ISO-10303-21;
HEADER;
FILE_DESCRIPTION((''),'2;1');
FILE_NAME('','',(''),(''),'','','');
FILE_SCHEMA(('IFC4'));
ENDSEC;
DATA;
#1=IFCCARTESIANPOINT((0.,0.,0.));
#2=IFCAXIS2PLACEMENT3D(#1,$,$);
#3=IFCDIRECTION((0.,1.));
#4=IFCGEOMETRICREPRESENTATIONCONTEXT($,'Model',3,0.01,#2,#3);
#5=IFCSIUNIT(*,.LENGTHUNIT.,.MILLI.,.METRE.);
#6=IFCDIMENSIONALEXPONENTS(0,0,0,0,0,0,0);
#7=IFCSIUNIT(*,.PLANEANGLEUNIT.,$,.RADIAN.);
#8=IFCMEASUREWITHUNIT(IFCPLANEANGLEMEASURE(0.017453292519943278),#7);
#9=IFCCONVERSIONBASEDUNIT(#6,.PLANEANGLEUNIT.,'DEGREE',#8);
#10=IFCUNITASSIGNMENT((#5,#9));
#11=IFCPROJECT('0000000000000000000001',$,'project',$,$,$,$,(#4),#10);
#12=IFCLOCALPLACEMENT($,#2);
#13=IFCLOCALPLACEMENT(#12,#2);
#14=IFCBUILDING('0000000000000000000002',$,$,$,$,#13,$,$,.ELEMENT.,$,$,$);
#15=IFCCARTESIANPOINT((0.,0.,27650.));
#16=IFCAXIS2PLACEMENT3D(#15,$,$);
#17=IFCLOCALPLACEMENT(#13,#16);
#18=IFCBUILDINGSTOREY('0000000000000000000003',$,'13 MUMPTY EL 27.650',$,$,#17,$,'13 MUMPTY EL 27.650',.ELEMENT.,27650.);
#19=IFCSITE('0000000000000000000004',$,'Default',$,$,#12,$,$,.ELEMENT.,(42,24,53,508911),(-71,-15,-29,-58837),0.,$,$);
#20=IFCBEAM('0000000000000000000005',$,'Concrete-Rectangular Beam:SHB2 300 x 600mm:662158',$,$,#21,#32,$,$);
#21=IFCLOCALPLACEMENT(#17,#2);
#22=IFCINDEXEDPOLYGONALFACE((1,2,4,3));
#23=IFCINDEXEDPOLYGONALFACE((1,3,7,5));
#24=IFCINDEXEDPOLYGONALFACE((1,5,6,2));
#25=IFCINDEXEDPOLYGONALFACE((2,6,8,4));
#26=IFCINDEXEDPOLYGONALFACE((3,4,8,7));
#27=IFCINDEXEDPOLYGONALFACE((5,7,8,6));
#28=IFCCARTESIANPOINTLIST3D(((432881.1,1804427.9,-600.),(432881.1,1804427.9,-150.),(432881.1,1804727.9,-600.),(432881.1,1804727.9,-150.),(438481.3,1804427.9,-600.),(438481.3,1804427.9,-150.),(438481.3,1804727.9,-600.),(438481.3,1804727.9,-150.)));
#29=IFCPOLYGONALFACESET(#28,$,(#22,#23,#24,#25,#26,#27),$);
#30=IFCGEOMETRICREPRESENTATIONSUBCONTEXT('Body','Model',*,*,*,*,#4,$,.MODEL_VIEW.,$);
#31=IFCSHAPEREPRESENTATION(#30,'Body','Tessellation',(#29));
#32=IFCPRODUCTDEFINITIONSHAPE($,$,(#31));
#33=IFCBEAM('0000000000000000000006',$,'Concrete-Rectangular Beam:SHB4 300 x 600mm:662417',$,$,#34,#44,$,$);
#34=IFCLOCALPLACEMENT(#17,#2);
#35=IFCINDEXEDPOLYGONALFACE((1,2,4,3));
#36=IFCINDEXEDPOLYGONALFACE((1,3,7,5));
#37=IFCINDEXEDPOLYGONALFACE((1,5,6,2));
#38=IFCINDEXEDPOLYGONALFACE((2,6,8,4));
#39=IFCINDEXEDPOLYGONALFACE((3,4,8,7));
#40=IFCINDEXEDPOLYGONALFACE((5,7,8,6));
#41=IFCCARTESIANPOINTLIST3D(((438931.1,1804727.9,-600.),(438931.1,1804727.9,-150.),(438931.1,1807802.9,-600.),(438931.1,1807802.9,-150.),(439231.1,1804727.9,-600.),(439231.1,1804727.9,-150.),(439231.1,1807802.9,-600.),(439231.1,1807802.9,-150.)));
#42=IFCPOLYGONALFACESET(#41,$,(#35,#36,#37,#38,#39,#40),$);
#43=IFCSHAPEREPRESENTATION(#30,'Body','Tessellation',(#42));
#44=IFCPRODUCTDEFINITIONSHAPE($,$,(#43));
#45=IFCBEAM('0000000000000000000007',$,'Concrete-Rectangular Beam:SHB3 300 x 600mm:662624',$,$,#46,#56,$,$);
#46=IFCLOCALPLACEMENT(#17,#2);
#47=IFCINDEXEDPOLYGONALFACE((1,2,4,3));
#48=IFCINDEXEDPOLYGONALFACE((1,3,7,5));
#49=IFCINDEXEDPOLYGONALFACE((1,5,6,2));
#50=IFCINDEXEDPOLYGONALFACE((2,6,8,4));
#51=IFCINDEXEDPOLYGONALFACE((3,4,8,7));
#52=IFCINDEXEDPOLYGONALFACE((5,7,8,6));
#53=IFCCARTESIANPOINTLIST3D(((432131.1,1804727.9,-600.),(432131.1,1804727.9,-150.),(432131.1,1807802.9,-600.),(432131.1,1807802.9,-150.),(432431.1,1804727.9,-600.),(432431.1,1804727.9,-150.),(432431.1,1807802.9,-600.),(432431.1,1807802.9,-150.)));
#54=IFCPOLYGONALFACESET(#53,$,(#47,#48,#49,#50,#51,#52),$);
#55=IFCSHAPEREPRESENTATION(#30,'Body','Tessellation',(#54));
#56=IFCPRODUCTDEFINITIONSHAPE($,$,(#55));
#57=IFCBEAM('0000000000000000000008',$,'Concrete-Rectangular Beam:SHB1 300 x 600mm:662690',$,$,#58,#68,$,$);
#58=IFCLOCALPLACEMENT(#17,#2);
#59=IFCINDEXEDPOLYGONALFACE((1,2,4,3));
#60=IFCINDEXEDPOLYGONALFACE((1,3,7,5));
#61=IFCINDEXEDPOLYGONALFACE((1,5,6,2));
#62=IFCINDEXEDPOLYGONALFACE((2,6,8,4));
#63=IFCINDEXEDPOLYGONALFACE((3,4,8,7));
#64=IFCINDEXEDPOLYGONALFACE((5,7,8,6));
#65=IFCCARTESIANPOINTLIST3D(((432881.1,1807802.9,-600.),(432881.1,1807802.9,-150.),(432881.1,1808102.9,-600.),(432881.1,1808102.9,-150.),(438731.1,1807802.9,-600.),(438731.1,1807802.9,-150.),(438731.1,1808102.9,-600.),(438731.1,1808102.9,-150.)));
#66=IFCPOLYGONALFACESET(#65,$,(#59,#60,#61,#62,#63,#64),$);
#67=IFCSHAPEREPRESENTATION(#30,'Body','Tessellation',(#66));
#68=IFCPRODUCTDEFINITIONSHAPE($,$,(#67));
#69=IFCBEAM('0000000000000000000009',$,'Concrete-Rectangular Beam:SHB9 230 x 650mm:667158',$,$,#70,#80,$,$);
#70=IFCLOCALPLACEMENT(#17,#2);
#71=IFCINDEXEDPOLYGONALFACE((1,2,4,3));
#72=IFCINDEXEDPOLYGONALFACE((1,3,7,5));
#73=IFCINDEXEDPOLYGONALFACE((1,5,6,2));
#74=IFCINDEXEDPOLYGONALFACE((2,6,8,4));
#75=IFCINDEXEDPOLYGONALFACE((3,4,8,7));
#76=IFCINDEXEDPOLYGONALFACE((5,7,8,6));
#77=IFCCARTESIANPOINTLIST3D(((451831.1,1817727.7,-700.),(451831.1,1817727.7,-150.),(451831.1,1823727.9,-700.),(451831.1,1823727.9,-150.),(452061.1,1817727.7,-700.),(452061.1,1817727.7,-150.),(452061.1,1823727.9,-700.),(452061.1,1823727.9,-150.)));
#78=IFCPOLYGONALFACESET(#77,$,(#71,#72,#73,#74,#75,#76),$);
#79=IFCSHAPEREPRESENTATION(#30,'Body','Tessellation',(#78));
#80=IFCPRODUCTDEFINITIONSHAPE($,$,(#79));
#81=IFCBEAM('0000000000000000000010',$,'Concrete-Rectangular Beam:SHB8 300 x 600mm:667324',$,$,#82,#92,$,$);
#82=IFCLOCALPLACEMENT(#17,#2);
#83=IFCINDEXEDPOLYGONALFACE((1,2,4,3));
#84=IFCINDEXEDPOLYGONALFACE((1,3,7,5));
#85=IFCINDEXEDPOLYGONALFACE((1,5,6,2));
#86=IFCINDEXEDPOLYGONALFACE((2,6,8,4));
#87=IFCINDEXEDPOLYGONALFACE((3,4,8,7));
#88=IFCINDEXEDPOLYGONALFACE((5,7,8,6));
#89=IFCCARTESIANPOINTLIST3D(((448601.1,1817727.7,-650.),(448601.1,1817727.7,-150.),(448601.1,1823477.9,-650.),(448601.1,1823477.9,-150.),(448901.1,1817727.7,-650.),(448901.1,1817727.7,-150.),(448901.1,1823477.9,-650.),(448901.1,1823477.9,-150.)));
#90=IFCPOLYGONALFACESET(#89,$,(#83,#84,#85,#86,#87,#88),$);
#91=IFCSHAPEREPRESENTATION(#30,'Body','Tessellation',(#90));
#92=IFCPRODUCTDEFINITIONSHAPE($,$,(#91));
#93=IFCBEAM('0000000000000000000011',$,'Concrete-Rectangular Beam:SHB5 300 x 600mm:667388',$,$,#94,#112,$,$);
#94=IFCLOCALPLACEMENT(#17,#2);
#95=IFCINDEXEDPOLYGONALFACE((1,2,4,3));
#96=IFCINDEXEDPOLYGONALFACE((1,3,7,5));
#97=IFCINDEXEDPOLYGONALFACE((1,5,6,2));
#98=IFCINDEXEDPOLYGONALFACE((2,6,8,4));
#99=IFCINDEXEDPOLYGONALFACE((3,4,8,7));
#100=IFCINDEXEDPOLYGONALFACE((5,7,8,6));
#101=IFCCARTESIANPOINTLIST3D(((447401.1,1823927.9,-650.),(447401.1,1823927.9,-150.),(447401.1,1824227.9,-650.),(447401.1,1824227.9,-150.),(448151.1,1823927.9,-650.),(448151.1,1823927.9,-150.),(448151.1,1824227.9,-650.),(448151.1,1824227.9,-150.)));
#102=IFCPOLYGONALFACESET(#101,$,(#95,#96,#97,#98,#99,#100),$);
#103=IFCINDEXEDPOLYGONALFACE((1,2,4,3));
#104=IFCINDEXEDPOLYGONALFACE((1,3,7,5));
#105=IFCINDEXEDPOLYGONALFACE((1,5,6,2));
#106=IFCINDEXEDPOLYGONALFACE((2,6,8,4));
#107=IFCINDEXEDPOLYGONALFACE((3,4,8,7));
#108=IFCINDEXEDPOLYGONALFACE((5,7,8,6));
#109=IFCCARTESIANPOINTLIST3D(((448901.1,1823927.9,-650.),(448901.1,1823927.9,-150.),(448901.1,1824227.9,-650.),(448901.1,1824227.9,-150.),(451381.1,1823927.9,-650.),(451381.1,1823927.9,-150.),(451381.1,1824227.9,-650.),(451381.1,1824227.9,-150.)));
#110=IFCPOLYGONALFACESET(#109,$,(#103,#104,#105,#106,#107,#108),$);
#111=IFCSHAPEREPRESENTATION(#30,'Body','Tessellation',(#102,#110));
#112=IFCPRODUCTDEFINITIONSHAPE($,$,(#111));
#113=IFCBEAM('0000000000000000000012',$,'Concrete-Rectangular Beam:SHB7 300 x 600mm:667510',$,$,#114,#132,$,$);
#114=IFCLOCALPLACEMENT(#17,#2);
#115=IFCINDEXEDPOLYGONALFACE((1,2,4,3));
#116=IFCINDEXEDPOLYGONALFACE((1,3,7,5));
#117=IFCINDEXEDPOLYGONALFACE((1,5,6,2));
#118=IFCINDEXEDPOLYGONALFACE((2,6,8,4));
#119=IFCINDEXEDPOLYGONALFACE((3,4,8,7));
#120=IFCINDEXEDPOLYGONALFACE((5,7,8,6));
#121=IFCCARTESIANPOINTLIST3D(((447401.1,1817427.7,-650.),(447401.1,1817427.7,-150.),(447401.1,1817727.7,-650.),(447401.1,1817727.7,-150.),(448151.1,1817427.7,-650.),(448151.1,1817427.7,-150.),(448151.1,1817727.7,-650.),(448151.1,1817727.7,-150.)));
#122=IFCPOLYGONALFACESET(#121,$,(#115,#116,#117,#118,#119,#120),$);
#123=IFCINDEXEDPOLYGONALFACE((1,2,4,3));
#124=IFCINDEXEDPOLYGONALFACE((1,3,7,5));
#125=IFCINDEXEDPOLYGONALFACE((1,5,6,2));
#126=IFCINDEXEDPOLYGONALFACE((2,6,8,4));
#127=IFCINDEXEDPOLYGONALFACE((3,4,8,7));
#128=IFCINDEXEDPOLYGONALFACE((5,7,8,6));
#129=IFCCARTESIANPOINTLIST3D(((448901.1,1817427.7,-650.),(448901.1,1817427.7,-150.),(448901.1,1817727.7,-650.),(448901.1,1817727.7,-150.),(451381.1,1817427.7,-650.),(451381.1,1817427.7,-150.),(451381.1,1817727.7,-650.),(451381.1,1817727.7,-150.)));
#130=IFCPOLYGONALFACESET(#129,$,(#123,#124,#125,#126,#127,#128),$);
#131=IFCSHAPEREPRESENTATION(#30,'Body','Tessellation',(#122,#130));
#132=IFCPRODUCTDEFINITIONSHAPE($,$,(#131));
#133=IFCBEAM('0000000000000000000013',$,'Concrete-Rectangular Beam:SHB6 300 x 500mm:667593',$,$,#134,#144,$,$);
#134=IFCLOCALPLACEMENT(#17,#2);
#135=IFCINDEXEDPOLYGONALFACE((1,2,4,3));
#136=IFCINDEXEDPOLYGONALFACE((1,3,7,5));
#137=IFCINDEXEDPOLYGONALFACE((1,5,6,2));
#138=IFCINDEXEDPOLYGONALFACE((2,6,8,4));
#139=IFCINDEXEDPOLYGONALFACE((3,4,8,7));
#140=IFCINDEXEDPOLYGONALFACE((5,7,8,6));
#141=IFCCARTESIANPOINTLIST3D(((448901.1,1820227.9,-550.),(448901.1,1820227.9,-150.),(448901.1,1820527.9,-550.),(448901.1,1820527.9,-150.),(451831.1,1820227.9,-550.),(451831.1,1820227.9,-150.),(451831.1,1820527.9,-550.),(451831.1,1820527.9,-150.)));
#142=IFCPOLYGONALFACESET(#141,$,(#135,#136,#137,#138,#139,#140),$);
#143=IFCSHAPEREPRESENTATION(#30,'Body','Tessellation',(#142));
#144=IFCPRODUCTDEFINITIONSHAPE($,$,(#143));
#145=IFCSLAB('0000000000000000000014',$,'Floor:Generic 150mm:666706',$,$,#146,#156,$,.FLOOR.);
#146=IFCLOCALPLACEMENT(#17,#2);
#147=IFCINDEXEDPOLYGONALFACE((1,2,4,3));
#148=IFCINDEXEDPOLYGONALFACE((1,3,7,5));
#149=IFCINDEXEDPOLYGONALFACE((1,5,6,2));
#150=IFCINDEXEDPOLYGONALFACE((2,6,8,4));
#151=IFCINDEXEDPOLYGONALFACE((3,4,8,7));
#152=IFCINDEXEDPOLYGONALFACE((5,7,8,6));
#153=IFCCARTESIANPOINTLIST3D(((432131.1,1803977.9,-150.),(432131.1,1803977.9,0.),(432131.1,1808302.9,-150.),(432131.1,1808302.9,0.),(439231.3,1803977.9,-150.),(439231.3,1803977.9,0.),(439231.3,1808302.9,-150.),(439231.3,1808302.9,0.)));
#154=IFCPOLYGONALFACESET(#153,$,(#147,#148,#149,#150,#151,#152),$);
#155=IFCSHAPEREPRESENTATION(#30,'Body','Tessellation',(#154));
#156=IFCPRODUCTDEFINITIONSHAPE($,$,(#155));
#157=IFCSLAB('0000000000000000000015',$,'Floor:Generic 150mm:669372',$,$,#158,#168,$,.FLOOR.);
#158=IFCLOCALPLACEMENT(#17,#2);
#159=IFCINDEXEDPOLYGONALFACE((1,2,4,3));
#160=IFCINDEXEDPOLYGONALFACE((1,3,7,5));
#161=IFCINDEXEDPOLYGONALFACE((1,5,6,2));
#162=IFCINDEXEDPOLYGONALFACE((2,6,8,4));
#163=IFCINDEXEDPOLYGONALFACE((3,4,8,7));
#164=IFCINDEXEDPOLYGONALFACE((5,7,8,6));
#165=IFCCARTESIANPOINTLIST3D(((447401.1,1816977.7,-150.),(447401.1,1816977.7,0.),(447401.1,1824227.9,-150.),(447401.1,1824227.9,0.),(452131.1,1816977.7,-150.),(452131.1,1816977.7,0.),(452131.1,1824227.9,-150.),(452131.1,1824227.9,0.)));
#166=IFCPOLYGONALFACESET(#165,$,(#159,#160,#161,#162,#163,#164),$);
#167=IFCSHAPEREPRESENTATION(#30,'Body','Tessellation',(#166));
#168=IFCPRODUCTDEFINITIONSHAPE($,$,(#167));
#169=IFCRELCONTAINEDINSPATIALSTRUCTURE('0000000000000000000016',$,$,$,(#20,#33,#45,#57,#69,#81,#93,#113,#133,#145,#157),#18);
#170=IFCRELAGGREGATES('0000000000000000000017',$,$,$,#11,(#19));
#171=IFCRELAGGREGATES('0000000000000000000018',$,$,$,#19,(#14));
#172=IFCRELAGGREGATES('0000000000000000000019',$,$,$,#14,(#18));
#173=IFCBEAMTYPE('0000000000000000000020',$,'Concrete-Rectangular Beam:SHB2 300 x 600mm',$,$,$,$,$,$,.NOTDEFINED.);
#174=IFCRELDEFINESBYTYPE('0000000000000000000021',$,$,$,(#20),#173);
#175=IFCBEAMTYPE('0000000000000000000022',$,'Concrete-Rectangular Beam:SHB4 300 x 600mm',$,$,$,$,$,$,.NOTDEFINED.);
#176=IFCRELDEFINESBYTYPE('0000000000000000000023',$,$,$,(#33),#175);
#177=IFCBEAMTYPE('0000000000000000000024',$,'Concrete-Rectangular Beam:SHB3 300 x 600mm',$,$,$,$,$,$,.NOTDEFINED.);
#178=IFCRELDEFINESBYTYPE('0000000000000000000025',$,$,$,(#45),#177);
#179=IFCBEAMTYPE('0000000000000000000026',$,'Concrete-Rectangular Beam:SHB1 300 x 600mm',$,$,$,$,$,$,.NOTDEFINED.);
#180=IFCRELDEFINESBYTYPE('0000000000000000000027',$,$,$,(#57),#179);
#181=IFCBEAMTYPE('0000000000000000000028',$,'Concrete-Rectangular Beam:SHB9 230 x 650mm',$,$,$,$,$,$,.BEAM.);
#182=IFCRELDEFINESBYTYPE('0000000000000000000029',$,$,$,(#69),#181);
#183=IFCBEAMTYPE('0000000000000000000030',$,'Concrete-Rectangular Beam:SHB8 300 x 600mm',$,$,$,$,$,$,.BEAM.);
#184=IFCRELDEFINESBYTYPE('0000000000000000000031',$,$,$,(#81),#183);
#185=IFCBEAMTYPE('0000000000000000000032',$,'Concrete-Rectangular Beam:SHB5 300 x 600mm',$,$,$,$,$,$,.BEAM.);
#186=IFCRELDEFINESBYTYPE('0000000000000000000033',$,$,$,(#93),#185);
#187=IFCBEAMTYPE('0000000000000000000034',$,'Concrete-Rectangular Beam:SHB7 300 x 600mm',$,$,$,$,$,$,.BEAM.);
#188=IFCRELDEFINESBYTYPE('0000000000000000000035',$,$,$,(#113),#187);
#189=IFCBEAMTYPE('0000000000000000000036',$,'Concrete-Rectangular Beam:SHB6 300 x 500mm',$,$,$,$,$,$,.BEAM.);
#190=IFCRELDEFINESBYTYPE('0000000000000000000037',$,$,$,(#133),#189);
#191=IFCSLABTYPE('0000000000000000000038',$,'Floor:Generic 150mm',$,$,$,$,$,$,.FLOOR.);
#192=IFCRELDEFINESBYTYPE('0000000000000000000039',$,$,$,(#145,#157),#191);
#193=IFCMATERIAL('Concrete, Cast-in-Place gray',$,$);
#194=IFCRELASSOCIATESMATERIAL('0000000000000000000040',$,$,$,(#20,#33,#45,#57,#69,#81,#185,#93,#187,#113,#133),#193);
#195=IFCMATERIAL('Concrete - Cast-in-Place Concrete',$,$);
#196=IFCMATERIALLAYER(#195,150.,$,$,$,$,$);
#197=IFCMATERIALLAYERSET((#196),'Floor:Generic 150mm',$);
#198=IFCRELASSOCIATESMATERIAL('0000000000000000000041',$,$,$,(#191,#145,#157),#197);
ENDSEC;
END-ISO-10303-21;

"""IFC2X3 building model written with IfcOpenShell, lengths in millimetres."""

from ifc_helpers import new_model, entity, si_unit, converted_unit, direction, frame, frame_2d, origin, origin_2d_with_axis, place, context, subcontext, project, spatial, rectangle, extrude, source, transform, mapped, material, layer, layer_set, layer_usage, type_object, type_shapes, element, save


model = new_model("IFC2X3")

# Units and contexts
model_context = context("Model", 3, precision=0.01, world=origin(), true_north=direction((0.0, 1.0)))
body_context = subcontext(model_context, "Body", "Model", "MODEL_VIEW")
ifc_project = project(units=[si_unit("LENGTHUNIT", "METRE", prefix="MILLI"), converted_unit("PLANEANGLEUNIT", "DEGREE", entity("IfcPlaneAngleMeasure", 0.017453292519943278), si_unit("PLANEANGLEUNIT", "RADIAN"), dimensions=[0, 0, 0, 0, 0, 0, 0])], contexts=[model_context])

# Site, building, storey
site_placement = place(None, origin())
site = spatial("IfcSite", under=ifc_project, at=site_placement, Name="Default", CompositionType="ELEMENT", RefLatitude=(42, 24, 53, 508911), RefLongitude=(-71, -15, -29, -58837), RefElevation=0.0)
building_placement = place(site_placement, origin())
building = spatial("IfcBuilding", under=site, at=building_placement, CompositionType="ELEMENT")
storey_placement = place(building_placement, frame((0.0, 0.0, 27650.0)))
storey = spatial("IfcBuildingStorey", under=building, at=storey_placement, Name="13 MUMPTY EL 27.650", LongName="13 MUMPTY EL 27.650", CompositionType="ELEMENT", Elevation=27650.0)

# Beams
ifc_material_1 = material(Name="Concrete, Cast-in-Place gray")
beam_type_1 = type_object("IfcBeamType", Name="Concrete-Rectangular Beam:SHB2 300 x 600mm", PredefinedType="NOTDEFINED")
beam_1_placement = place(storey_placement, frame((432881.1, 1804427.9, 0.0)))
element("IfcBeam", 1, at=beam_1_placement, inside=storey, type_object=beam_type_1, material=ifc_material_1, Name="Concrete-Rectangular Beam:SHB2 300 x 600mm:662158", context=body_context, shape_type="SweptSolid", body=[
    extrude(rectangle(XDim=450.0, YDim=300.0, at=origin_2d_with_axis()), frame((0.0, 150.0, -375.0), z_axis=(1.0, 0.0, 0.0), x_axis=(0.0, 0.0, -1.0)), (0.0, 0.0, 1.0), 5600.2),
])
beam_type_2 = type_object("IfcBeamType", Name="Concrete-Rectangular Beam:SHB4 300 x 600mm", PredefinedType="NOTDEFINED")
beam_2_placement = place(storey_placement, frame((438931.1, 1807842.4, 0.0), z_axis=(0.0, 0.0, 1.0), x_axis=(0.0, -1.0, 0.0)))
element("IfcBeam", 2, at=beam_2_placement, inside=storey, type_object=beam_type_2, material=ifc_material_1, Name="Concrete-Rectangular Beam:SHB4 300 x 600mm:662417", context=body_context, shape_type="SweptSolid", body=[
    extrude(rectangle(XDim=450.0, YDim=300.0, at=origin_2d_with_axis()), frame((39.5, 150.0, -375.0), z_axis=(1.0, 0.0, 0.0), x_axis=(0.0, 0.0, -1.0)), (0.0, 0.0, 1.0), 3075.0),
])
beam_type_3 = type_object("IfcBeamType", Name="Concrete-Rectangular Beam:SHB3 300 x 600mm", PredefinedType="NOTDEFINED")
beam_3_placement = place(storey_placement, frame((432131.1, 1807802.9, 0.0), z_axis=(0.0, 0.0, 1.0), x_axis=(0.0, -1.0, 0.0)))
element("IfcBeam", 3, at=beam_3_placement, inside=storey, type_object=beam_type_3, material=ifc_material_1, Name="Concrete-Rectangular Beam:SHB3 300 x 600mm:662624", context=body_context, shape_type="SweptSolid", body=[
    extrude(rectangle(XDim=450.0, YDim=300.0, at=origin_2d_with_axis()), frame((0.0, 150.0, -375.0), z_axis=(1.0, 0.0, 0.0), x_axis=(0.0, 0.0, -1.0)), (0.0, 0.0, 1.0), 3075.0),
])
beam_type_4 = type_object("IfcBeamType", Name="Concrete-Rectangular Beam:SHB1 300 x 600mm", PredefinedType="NOTDEFINED")
beam_4_placement = place(storey_placement, frame((432881.1, 1807802.9, 0.0)))
element("IfcBeam", 4, at=beam_4_placement, inside=storey, type_object=beam_type_4, material=ifc_material_1, Name="Concrete-Rectangular Beam:SHB1 300 x 600mm:662690", context=body_context, shape_type="SweptSolid", body=[
    extrude(rectangle(XDim=450.0, YDim=300.0, at=origin_2d_with_axis()), frame((0.0, 150.0, -375.0), z_axis=(1.0, 0.0, 0.0), x_axis=(0.0, 0.0, -1.0)), (0.0, 0.0, 1.0), 5850.0),
])
beam_type_5 = type_object("IfcBeamType", Name="Concrete-Rectangular Beam:SHB9 230 x 650mm", PredefinedType="BEAM")
beam_5_placement = place(storey_placement, frame((451831.1, 1823727.9, -50.0), z_axis=(0.0, 0.0, 1.0), x_axis=(0.0, -1.0, 0.0)))
element("IfcBeam", 5, at=beam_5_placement, inside=storey, type_object=beam_type_5, material=ifc_material_1, Name="Concrete-Rectangular Beam:SHB9 230 x 650mm:667158", context=body_context, shape_type="SweptSolid", body=[
    extrude(rectangle(XDim=550.0, YDim=230.0, at=frame_2d((0.0, 0.0), x_axis=(1.0, 0.0))), frame((0.0, 115.0, -375.0), z_axis=(1.0, 0.0, 0.0), x_axis=(0.0, 0.0, -1.0)), (0.0, 0.0, 1.0), 6000.2),
])
beam_type_6 = type_object("IfcBeamType", Name="Concrete-Rectangular Beam:SHB8 300 x 600mm", PredefinedType="BEAM")
beam_6_placement = place(storey_placement, frame((448901.1, 1817727.7, -50.0), z_axis=(0.0, 0.0, 1.0), x_axis=(0.0, 1.0, 0.0)))
element("IfcBeam", 6, at=beam_6_placement, inside=storey, type_object=beam_type_6, material=ifc_material_1, Name="Concrete-Rectangular Beam:SHB8 300 x 600mm:667324", context=body_context, shape_type="SweptSolid", body=[
    extrude(rectangle(XDim=500.0, YDim=300.0, at=frame_2d((0.0, 0.0), x_axis=(1.0, 0.0))), frame((0.0, 150.0, -350.0), z_axis=(1.0, 0.0, 0.0), x_axis=(0.0, 0.0, -1.0)), (0.0, 0.0, 1.0), 5750.2),
])
beam_type_7 = type_object("IfcBeamType", Name="Concrete-Rectangular Beam:SHB5 300 x 600mm", PredefinedType="BEAM", material=ifc_material_1)
shared_shape_1 = source(origin(), body_context, "Body", "SweptSolid", [
    extrude(rectangle(XDim=500.0, YDim=300.0, at=frame_2d((0.0, 0.0), x_axis=(1.0, 0.0))), frame((447401.1, 1824077.9, 27250.0), z_axis=(1.0, 0.0, 0.0), x_axis=(0.0, 0.0, -1.0)), (0.0, 0.0, 1.0), 750.0),
    extrude(rectangle(XDim=500.0, YDim=300.0, at=frame_2d((0.0, 0.0), x_axis=(1.0, 0.0))), frame((448901.1, 1824077.9, 27250.0), z_axis=(1.0, 0.0, 0.0), x_axis=(0.0, 0.0, -1.0)), (0.0, 0.0, 1.0), 2480.0),
])
type_shapes(beam_type_7, [shared_shape_1])
beam_7_placement = place(storey_placement, frame((0.0, 0.0, -27650.0)))
element("IfcBeam", 7, at=beam_7_placement, inside=storey, type_object=beam_type_7, material=ifc_material_1, Name="Concrete-Rectangular Beam:SHB5 300 x 600mm:667388", context=body_context, shape_type="MappedRepresentation", body=[
    mapped(shared_shape_1, transform((0.0, 0.0, 0.0), scale=1.0)),
])
beam_type_8 = type_object("IfcBeamType", Name="Concrete-Rectangular Beam:SHB7 300 x 600mm", PredefinedType="BEAM", material=ifc_material_1)
shared_shape_2 = source(origin(), body_context, "Body", "SweptSolid", [
    extrude(rectangle(XDim=500.0, YDim=300.0, at=frame_2d((0.0, 0.0), x_axis=(1.0, 0.0))), frame((447401.1, 1817577.7, 27250.0), z_axis=(1.0, 0.0, 0.0), x_axis=(0.0, 0.0, -1.0)), (0.0, 0.0, 1.0), 750.0),
    extrude(rectangle(XDim=500.0, YDim=300.0, at=frame_2d((0.0, 0.0), x_axis=(1.0, 0.0))), frame((448901.1, 1817577.7, 27250.0), z_axis=(1.0, 0.0, 0.0), x_axis=(0.0, 0.0, -1.0)), (0.0, 0.0, 1.0), 2480.0),
])
type_shapes(beam_type_8, [shared_shape_2])
beam_8_placement = place(storey_placement, frame((0.0, 0.0, -27650.0)))
element("IfcBeam", 8, at=beam_8_placement, inside=storey, type_object=beam_type_8, material=ifc_material_1, Name="Concrete-Rectangular Beam:SHB7 300 x 600mm:667510", context=body_context, shape_type="MappedRepresentation", body=[
    mapped(shared_shape_2, transform((0.0, 0.0, 0.0), scale=1.0)),
])
beam_type_9 = type_object("IfcBeamType", Name="Concrete-Rectangular Beam:SHB6 300 x 500mm", PredefinedType="BEAM")
beam_9_placement = place(storey_placement, frame((448901.1, 1820227.9, -50.0)))
element("IfcBeam", 9, at=beam_9_placement, inside=storey, type_object=beam_type_9, material=ifc_material_1, Name="Concrete-Rectangular Beam:SHB6 300 x 500mm:667593", context=body_context, shape_type="SweptSolid", body=[
    extrude(rectangle(XDim=400.0, YDim=300.0, at=frame_2d((0.0, 0.0), x_axis=(1.0, 0.0))), frame((0.0, 150.0, -300.0), z_axis=(1.0, 0.0, 0.0), x_axis=(0.0, 0.0, -1.0)), (0.0, 0.0, 1.0), 2930.0),
])

# Slabs
ifc_material_2 = material(Name="Concrete - Cast-in-Place Concrete")
ifc_layer = layer(ifc_material_2, 150.0)
ifc_layer_set = layer_set([ifc_layer], Name="Floor:Generic 150mm")
ifc_layer_usage_1 = layer_usage(ifc_layer_set, "AXIS3", "POSITIVE", 0.0)
slab_type = type_object("IfcSlabType", Name="Floor:Generic 150mm", PredefinedType="FLOOR", material=ifc_layer_set)
slab_1_placement = place(storey_placement, origin())
element("IfcSlab", 10, at=slab_1_placement, inside=storey, type_object=slab_type, material=ifc_layer_usage_1, Name="Floor:Generic 150mm:666706", PredefinedType="FLOOR", context=body_context, shape_type="SweptSolid", body=[
    extrude(rectangle(XDim=4325.0, YDim=7100.2, at=frame_2d((0.0, 0.0), x_axis=(1.0, 0.0))), frame((435681.2, 1806140.4, 0.0), z_axis=(0.0, 0.0, -1.0), x_axis=(0.0, 1.0, 0.0)), (0.0, 0.0, 1.0), 150.0),
])
ifc_layer_usage_2 = layer_usage(ifc_layer_set, "AXIS3", "POSITIVE", 0.0)
slab_2_placement = place(storey_placement, origin())
element("IfcSlab", 11, at=slab_2_placement, inside=storey, type_object=slab_type, material=ifc_layer_usage_2, Name="Floor:Generic 150mm:669372", PredefinedType="FLOOR", context=body_context, shape_type="SweptSolid", body=[
    extrude(rectangle(XDim=7250.2, YDim=4730.0, at=origin_2d_with_axis()), frame((449766.1, 1820602.8, 0.0), z_axis=(0.0, 0.0, -1.0), x_axis=(0.0, 1.0, 0.0)), (0.0, 0.0, 1.0), 150.0),
])

save(model, "model.ifc")
